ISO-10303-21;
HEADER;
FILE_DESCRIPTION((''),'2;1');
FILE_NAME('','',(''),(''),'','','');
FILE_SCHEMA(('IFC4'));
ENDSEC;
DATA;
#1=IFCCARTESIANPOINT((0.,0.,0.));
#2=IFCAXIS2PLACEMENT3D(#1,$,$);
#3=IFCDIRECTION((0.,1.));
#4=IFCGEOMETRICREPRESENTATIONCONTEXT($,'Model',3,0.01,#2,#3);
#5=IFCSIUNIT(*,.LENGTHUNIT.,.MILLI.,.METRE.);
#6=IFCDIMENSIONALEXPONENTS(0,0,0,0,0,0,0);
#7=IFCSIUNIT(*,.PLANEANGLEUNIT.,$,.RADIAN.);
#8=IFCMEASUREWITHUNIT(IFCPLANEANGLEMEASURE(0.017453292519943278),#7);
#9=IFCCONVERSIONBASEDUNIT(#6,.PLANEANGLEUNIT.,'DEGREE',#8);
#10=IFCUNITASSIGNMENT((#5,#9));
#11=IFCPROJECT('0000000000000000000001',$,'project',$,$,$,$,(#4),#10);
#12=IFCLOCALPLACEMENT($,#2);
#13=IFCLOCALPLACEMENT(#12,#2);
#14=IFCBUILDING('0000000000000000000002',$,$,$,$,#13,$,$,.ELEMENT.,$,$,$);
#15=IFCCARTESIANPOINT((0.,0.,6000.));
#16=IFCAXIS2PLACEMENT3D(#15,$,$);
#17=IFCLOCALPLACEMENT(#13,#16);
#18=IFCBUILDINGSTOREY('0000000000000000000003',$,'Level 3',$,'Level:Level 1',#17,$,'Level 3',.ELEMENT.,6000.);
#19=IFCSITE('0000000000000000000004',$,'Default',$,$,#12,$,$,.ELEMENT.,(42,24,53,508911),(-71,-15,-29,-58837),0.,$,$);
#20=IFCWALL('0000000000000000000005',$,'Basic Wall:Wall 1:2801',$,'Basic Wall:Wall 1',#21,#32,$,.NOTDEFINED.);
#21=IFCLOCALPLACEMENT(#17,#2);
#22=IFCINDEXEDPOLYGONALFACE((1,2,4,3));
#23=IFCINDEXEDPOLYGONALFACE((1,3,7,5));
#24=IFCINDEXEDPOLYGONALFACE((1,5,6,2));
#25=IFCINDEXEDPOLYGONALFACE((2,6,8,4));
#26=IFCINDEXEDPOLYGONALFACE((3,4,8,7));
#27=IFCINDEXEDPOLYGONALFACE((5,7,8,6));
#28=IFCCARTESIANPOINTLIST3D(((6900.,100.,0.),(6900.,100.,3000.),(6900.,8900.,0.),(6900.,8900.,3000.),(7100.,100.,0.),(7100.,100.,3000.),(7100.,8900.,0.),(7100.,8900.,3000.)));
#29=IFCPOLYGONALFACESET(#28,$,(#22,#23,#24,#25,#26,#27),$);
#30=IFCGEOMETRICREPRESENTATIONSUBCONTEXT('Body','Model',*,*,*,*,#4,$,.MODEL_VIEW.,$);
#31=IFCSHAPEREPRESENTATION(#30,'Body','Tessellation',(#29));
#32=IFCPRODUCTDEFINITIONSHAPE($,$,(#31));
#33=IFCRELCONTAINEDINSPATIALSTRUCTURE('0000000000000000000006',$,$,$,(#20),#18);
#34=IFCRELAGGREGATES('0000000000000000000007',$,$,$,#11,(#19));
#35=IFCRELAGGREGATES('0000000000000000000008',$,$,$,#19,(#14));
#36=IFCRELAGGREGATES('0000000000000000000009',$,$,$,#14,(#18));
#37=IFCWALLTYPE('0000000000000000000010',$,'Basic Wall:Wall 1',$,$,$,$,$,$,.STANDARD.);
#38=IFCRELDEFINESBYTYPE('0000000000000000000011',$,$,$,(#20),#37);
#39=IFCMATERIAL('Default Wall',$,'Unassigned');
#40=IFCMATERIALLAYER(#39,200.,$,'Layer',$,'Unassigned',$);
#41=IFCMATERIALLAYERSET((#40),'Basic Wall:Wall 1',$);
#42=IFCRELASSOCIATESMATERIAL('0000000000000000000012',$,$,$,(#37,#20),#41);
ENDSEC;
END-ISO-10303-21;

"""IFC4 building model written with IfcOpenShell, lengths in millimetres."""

from ifc_helpers import new_model, entity, si_unit, converted_unit, direction, frame, frame_2d, origin, place, context, subcontext, project, spatial, rectangle, extrude, material, layer, layer_set, layer_usage, type_object, element, save


model = new_model("IFC4")

# Units and contexts
model_context = context("Model", 3, precision=0.01, world=origin(), true_north=direction((0.0, 1.0)))
body_context = subcontext(model_context, "Body", "Model", "MODEL_VIEW")
ifc_project = project(units=[si_unit("LENGTHUNIT", "METRE", prefix="MILLI"), converted_unit("PLANEANGLEUNIT", "DEGREE", entity("IfcPlaneAngleMeasure", 0.017453292519943278), si_unit("PLANEANGLEUNIT", "RADIAN"), dimensions=[0, 0, 0, 0, 0, 0, 0])], contexts=[model_context])

# Site, building, storey
site_placement = place(None, origin())
site = spatial("IfcSite", under=ifc_project, at=site_placement, Name="Default", CompositionType="ELEMENT", RefLatitude=(42, 24, 53, 508911), RefLongitude=(-71, -15, -29, -58837), RefElevation=0.0)
building_placement = place(site_placement, origin())
building = spatial("IfcBuilding", under=site, at=building_placement, CompositionType="ELEMENT")
storey_placement = place(building_placement, frame((0.0, 0.0, 6000.0)))
storey = spatial("IfcBuildingStorey", under=building, at=storey_placement, Name="Level 3", ObjectType="Level:Level 1", LongName="Level 3", CompositionType="ELEMENT", Elevation=6000.0)

# Wall
ifc_material_1 = material(Name="Default Wall", Category="Unassigned")
ifc_layer_1 = layer(ifc_material_1, 200.0, Name="Layer", Category="Unassigned")
ifc_layer_set_1 = layer_set([ifc_layer_1], Name="Basic Wall:Wall 1")
wall_type = type_object("IfcWallType", Name="Basic Wall:Wall 1", PredefinedType="STANDARD", material=ifc_layer_set_1)
ifc_layer_usage_1 = layer_usage(ifc_layer_set_1, "AXIS2", "NEGATIVE", 100.0)
wall_1_placement = place(storey_placement, frame((7000.0, 100.0, 0.0), z_axis=(0.0, 0.0, 1.0), x_axis=(0.0, 1.0, 0.0)))
element("IfcWall", 1, at=wall_1_placement, inside=storey, type_object=wall_type, material=ifc_layer_usage_1, Name="Basic Wall:Wall 1:2801", ObjectType="Basic Wall:Wall 1", PredefinedType="NOTDEFINED", context=body_context, shape_type="SweptSolid", body=[
    extrude(rectangle(XDim=8800.0, YDim=200.0, at=frame_2d((4400.0, 0.0), x_axis=(-1.0, 0.0))), origin(), (0.0, 0.0, 1.0), 3000.0),
])

save(model, "model.ifc")
